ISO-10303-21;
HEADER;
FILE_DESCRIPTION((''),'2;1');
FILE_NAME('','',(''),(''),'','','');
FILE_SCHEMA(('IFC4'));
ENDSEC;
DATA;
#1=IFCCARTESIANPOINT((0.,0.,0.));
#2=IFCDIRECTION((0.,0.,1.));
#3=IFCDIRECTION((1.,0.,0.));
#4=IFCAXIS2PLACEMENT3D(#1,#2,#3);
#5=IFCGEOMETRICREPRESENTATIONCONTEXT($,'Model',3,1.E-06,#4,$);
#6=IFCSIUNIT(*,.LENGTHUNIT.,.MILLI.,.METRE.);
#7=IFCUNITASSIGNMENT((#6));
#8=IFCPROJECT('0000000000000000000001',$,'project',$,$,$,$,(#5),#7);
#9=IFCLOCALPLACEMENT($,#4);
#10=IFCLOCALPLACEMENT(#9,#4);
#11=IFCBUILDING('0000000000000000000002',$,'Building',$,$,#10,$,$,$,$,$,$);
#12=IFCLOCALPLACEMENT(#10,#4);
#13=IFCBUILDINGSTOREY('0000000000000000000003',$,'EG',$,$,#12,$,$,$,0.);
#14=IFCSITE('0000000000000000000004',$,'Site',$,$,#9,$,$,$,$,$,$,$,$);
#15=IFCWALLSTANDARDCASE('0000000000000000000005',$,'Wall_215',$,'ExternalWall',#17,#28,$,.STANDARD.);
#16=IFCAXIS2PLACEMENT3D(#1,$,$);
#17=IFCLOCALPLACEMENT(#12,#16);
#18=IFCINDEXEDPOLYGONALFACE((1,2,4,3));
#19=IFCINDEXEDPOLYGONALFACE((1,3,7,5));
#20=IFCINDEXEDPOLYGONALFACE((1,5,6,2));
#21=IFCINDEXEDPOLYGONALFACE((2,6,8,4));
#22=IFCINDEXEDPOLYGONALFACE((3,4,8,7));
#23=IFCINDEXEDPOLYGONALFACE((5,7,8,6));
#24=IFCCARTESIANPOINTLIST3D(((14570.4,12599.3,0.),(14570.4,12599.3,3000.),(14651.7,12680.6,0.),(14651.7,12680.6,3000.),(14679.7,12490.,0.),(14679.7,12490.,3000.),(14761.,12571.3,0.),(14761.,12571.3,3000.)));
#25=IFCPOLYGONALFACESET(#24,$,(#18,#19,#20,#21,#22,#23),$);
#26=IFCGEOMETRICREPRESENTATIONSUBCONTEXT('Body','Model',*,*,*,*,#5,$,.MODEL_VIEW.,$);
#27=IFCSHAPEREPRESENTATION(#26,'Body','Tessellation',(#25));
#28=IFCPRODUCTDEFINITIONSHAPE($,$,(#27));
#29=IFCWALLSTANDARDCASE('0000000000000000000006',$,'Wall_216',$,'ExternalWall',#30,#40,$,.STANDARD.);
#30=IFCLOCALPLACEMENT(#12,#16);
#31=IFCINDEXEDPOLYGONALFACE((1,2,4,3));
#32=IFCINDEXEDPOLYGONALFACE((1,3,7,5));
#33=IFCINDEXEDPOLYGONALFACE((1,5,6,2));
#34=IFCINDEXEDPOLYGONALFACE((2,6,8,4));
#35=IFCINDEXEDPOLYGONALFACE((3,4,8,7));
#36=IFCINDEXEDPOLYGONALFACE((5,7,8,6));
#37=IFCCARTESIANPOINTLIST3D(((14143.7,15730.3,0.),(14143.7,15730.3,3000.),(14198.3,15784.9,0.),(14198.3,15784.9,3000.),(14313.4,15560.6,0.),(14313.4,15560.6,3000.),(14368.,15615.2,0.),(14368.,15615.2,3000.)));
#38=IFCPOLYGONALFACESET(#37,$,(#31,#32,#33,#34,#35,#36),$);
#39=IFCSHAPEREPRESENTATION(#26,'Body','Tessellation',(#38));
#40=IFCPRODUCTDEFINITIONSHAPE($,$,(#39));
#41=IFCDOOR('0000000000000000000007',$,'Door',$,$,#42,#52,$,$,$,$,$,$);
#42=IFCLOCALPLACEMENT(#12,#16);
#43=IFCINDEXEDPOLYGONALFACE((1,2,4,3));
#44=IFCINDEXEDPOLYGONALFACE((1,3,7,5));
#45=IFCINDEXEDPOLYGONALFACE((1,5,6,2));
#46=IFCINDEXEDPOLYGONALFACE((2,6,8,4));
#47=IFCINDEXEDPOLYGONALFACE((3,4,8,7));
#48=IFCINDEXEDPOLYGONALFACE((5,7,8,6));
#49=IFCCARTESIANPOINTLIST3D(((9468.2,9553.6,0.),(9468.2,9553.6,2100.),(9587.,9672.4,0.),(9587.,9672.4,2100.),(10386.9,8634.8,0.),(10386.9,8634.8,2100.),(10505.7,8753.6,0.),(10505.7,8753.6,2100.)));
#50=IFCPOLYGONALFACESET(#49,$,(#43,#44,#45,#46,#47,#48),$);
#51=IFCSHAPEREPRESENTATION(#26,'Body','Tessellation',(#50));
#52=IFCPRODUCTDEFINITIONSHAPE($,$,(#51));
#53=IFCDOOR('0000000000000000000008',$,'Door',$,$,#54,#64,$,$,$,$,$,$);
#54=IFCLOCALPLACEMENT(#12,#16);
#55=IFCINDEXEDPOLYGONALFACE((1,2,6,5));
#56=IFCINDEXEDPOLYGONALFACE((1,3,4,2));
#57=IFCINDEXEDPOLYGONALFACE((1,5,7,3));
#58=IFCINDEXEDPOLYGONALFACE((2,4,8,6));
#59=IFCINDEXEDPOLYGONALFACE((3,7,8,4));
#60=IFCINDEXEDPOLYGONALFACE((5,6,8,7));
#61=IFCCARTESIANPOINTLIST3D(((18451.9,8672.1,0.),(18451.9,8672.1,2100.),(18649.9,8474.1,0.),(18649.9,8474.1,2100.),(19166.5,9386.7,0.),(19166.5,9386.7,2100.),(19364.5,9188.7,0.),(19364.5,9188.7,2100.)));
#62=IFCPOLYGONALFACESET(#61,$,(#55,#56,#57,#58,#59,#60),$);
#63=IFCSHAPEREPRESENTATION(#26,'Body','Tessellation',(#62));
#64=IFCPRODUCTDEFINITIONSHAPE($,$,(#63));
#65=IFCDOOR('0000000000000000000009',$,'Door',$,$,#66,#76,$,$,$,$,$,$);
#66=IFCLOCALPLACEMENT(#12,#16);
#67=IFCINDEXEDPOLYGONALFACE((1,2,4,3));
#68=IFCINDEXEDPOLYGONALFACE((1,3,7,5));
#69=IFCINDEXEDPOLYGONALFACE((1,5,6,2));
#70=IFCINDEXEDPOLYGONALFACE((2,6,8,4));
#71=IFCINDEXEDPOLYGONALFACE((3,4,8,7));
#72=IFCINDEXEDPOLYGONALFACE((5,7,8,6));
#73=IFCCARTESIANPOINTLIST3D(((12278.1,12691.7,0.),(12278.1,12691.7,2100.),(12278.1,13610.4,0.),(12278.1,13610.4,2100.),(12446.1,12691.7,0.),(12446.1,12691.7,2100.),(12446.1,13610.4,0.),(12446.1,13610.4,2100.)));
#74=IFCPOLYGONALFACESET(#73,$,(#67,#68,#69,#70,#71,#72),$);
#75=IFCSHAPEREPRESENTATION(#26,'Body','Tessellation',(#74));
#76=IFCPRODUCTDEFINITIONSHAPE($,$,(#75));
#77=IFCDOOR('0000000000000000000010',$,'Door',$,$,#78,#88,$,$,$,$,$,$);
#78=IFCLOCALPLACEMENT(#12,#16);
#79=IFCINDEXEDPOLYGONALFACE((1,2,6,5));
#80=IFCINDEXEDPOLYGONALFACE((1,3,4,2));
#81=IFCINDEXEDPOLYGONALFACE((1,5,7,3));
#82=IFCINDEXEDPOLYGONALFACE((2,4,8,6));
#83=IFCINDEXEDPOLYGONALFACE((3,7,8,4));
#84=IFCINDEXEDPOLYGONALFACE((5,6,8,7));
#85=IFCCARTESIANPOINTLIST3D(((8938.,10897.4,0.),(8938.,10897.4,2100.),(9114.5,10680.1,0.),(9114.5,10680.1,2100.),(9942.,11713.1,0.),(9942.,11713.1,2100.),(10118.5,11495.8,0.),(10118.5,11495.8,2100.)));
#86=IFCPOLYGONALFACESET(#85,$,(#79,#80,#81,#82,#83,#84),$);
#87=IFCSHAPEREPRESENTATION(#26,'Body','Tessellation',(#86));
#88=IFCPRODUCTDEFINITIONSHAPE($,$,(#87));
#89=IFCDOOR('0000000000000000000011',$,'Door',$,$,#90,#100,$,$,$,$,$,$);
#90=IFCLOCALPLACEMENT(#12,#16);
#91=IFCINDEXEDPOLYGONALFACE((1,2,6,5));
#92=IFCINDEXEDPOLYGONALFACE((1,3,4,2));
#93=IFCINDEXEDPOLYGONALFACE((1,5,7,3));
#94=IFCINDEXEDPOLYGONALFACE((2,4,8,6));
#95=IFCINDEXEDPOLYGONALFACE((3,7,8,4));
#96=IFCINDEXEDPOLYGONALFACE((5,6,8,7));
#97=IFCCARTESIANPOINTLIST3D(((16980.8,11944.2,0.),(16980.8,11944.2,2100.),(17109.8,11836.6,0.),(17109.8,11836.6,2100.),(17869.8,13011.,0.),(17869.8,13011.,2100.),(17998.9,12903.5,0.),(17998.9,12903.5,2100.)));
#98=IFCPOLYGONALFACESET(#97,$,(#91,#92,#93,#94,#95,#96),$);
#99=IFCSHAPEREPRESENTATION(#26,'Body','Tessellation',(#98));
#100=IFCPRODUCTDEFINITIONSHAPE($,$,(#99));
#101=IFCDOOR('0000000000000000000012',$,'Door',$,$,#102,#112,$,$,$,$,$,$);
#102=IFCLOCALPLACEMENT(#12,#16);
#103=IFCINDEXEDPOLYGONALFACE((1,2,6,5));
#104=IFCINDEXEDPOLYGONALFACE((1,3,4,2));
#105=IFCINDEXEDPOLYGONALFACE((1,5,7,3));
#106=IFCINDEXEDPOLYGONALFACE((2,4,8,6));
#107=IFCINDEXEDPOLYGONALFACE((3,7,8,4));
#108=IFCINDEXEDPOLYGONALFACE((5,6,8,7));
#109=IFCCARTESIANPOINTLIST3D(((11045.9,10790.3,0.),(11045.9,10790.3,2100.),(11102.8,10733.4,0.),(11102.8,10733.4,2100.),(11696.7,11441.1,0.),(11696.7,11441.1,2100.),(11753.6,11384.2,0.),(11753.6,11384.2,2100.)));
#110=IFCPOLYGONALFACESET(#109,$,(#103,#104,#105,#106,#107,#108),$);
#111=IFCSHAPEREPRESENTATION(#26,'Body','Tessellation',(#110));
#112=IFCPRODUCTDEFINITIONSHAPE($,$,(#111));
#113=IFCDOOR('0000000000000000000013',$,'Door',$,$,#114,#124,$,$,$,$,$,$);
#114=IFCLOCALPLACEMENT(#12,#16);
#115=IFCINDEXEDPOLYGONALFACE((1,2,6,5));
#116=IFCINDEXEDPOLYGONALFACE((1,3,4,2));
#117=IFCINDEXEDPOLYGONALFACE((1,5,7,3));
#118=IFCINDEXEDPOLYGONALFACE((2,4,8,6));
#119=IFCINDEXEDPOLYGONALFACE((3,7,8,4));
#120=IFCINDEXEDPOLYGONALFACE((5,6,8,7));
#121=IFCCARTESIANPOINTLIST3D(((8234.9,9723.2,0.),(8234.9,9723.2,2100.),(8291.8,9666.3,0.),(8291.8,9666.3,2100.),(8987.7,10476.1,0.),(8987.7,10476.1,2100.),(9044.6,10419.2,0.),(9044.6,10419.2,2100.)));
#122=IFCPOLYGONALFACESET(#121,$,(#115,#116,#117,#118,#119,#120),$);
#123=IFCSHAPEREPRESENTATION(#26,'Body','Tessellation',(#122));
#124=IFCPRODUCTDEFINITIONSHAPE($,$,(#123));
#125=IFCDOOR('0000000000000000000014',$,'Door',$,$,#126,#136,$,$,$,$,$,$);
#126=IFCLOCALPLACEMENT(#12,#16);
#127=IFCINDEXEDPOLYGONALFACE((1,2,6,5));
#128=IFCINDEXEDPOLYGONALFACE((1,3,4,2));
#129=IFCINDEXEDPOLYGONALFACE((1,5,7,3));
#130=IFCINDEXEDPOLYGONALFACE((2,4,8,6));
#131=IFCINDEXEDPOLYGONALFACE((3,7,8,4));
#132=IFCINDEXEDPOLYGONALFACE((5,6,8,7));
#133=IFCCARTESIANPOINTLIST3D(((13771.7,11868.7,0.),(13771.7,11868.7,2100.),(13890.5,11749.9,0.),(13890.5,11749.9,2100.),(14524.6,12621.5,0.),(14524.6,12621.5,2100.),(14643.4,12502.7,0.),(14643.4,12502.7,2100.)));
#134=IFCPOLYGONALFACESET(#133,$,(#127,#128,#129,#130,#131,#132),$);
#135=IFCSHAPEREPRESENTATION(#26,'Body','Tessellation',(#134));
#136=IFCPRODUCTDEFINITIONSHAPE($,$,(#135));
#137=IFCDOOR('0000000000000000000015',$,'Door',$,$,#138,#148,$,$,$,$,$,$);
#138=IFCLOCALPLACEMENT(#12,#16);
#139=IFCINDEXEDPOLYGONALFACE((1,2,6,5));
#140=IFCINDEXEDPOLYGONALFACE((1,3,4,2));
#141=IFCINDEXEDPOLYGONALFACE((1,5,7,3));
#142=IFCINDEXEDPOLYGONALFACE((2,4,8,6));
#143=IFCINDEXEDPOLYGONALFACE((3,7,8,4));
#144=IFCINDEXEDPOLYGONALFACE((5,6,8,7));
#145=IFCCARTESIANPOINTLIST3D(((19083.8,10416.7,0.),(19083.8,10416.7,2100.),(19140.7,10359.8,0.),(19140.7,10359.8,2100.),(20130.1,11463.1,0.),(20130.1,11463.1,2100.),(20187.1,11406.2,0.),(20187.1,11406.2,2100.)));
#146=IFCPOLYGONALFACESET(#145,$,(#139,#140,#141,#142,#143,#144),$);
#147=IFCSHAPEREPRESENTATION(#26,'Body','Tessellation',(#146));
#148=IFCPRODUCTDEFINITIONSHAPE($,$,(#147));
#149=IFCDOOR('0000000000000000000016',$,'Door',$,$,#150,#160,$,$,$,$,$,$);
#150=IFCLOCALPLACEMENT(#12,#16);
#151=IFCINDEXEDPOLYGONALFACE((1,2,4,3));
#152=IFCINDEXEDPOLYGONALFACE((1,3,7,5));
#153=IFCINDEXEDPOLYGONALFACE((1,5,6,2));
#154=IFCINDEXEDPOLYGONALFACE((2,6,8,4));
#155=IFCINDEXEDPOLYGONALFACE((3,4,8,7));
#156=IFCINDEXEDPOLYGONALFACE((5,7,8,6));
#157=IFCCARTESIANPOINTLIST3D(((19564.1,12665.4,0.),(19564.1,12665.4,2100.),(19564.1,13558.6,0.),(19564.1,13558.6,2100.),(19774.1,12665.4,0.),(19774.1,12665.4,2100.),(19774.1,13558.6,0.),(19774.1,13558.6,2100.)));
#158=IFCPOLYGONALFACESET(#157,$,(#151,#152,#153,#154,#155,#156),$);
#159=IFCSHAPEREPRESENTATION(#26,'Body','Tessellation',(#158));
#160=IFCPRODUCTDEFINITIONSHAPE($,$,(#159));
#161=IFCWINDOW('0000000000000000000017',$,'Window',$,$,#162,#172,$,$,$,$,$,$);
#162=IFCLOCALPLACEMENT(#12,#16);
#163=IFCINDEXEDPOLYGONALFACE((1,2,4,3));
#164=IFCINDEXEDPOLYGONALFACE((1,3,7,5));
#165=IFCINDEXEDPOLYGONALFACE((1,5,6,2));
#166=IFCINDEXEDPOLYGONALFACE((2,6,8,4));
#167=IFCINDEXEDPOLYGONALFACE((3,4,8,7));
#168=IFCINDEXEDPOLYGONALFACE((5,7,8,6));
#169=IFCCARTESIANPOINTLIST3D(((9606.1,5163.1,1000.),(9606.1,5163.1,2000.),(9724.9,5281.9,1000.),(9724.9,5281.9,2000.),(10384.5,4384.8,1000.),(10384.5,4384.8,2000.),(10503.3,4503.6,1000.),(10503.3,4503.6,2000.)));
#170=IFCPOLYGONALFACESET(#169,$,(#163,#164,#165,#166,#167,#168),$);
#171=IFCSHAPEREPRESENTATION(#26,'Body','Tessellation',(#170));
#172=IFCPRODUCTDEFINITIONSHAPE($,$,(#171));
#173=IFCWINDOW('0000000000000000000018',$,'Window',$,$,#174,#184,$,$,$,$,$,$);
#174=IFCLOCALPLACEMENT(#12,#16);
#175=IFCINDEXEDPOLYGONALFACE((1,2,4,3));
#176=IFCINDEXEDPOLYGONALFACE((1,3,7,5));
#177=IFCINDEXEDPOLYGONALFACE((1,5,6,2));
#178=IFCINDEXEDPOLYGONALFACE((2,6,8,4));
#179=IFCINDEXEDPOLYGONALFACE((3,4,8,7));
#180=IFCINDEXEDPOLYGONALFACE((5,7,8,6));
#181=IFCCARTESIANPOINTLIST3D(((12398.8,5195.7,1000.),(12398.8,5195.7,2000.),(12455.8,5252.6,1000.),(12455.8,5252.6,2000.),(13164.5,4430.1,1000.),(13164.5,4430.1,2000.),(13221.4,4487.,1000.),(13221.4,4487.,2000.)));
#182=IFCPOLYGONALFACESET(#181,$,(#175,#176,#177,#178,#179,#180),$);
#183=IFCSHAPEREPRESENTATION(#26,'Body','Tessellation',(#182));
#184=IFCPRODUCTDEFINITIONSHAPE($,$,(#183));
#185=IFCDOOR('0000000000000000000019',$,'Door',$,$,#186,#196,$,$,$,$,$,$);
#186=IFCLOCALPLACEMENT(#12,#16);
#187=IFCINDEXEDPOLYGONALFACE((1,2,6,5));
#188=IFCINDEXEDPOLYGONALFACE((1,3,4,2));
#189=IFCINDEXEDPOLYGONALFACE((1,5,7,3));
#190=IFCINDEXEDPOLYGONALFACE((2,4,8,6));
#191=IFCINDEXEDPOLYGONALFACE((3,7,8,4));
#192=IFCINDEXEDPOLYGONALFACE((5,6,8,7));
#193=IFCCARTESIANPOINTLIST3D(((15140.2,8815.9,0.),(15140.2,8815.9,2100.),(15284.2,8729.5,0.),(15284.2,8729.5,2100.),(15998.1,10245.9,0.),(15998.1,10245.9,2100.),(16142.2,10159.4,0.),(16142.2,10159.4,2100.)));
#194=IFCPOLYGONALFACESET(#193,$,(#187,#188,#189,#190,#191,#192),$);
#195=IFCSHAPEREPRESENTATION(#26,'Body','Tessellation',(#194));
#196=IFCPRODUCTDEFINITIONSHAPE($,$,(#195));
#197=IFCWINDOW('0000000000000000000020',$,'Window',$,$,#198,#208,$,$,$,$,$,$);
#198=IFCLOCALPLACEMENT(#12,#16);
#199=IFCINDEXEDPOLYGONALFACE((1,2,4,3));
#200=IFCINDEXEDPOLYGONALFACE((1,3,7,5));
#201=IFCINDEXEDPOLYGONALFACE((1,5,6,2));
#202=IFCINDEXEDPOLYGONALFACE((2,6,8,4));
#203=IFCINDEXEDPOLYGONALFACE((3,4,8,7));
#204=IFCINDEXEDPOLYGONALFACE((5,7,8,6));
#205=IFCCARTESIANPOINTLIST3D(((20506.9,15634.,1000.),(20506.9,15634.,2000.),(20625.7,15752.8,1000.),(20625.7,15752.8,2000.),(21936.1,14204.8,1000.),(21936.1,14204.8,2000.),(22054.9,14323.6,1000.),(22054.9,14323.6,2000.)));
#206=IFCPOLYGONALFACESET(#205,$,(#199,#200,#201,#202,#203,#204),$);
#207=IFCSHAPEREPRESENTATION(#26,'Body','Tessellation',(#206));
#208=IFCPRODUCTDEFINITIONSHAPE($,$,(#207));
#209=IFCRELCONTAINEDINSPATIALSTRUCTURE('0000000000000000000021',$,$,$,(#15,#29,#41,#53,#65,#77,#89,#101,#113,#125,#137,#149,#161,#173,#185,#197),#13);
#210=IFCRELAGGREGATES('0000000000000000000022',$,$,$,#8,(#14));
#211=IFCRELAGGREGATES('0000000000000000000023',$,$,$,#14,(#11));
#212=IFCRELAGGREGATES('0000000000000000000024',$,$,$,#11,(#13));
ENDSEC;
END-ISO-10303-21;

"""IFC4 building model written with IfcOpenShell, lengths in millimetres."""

from ifc_helpers import new_model, si_unit, frame, origin_with_axes, place, context, subcontext, project, spatial, rectangle, extrude, element, save


model = new_model("IFC4")

# Units and contexts
model_context = context("Model", 3, precision=1e-06, world=origin_with_axes())
body_context = subcontext(model_context, "Body", "Model", "MODEL_VIEW")
ifc_project = project(units=[si_unit("LENGTHUNIT", "METRE", prefix="MILLI")], contexts=[model_context])

# Site, building, storey
site_placement = place(None, origin_with_axes())
site = spatial("IfcSite", under=ifc_project, at=site_placement, Name="Site")
building_placement = place(site_placement, origin_with_axes())
building = spatial("IfcBuilding", under=site, at=building_placement, Name="Building")
storey_placement = place(building_placement, origin_with_axes())
storey = spatial("IfcBuildingStorey", under=building, at=storey_placement, Name="EG", Elevation=0.0)

# Walls
wall_1_placement = place(storey_placement, origin_with_axes())
element("IfcWallStandardCase", 1, at=wall_1_placement, inside=storey, Name="Wall_215", ObjectType="ExternalWall", PredefinedType="STANDARD", context=body_context, shape_type="SweptSolid", body=[
    extrude(rectangle(XDim=154.6, YDim=115.0), frame((14665.7, 12585.3, 0.0), z_axis=(0.0, 0.0, 1.0), x_axis=(0.707107, -0.707107, 0.0)), (0.0, 0.0, 1.0), 3000.0),
])
wall_2_placement = place(storey_placement, origin_with_axes())
element("IfcWallStandardCase", 2, at=wall_2_placement, inside=storey, Name="Wall_216", ObjectType="ExternalWall", PredefinedType="STANDARD", context=body_context, shape_type="SweptSolid", body=[
    extrude(rectangle(XDim=77.3, YDim=240.0), frame((14255.8, 15672.8, 0.0), z_axis=(0.0, 0.0, 1.0), x_axis=(-0.707107, -0.707107, 0.0)), (0.0, 0.0, 1.0), 3000.0),
])

# Doors
door_1_placement = place(storey_placement, origin_with_axes())
element("IfcDoor", 3, at=door_1_placement, inside=storey, Name="Door", context=body_context, shape_type="SweptSolid", body=[
    extrude(rectangle(XDim=1299.3, YDim=168.0), frame((9986.9, 9153.6, 0.0), z_axis=(0.0, 0.0, 1.0), x_axis=(0.707107, -0.707107, 0.0)), (0.0, 0.0, 1.0), 2100.0),
])
door_2_placement = place(storey_placement, origin_with_axes())
element("IfcDoor", 4, at=door_2_placement, inside=storey, Name="Door", context=body_context, shape_type="SweptSolid", body=[
    extrude(rectangle(XDim=1010.6, YDim=280.0), frame((18908.2, 8930.4, 0.0), z_axis=(0.0, 0.0, 1.0), x_axis=(-0.707107, -0.707107, 0.0)), (0.0, 0.0, 1.0), 2100.0),
])
door_3_placement = place(storey_placement, origin_with_axes())
element("IfcDoor", 5, at=door_3_placement, inside=storey, Name="Door", context=body_context, shape_type="SweptSolid", body=[
    extrude(rectangle(XDim=918.8, YDim=168.0), frame((12362.1, 13151.0, 0.0), z_axis=(0.0, 0.0, 1.0), x_axis=(0.0, -1.0, 0.0)), (0.0, 0.0, 1.0), 2100.0),
])
door_4_placement = place(storey_placement, origin_with_axes())
element("IfcDoor", 6, at=door_4_placement, inside=storey, Name="Door", context=body_context, shape_type="SweptSolid", body=[
    extrude(rectangle(XDim=1293.6, YDim=280.0), frame((9528.3, 11196.6, 0.0), z_axis=(0.0, 0.0, 1.0), x_axis=(-0.776114, -0.630593, 0.0)), (0.0, 0.0, 1.0), 2100.0),
])
door_5_placement = place(storey_placement, origin_with_axes())
element("IfcDoor", 7, at=door_5_placement, inside=storey, Name="Door", context=body_context, shape_type="SweptSolid", body=[
    extrude(rectangle(XDim=1388.7, YDim=168.0), frame((17489.8, 12423.8, 0.0), z_axis=(0.0, 0.0, 1.0), x_axis=(-0.640184, -0.768221, 0.0)), (0.0, 0.0, 1.0), 2100.0),
])
door_6_placement = place(storey_placement, origin_with_axes())
element("IfcDoor", 8, at=door_6_placement, inside=storey, Name="Door", context=body_context, shape_type="SweptSolid", body=[
    extrude(rectangle(XDim=920.3, YDim=80.5), frame((11399.7, 11087.2, 0.0), z_axis=(0.0, 0.0, 1.0), x_axis=(-0.707107, -0.707107, 0.0)), (0.0, 0.0, 1.0), 2100.0),
])
door_7_placement = place(storey_placement, origin_with_axes())
element("IfcDoor", 9, at=door_7_placement, inside=storey, Name="Door", context=body_context, shape_type="SweptSolid", body=[
    extrude(rectangle(XDim=1064.7, YDim=80.5), frame((8639.8, 10071.2, 0.0), z_axis=(0.0, 0.0, 1.0), x_axis=(0.707107, 0.707107, 0.0)), (0.0, 0.0, 1.0), 2100.0),
])
door_8_placement = place(storey_placement, origin_with_axes())
element("IfcDoor", 10, at=door_8_placement, inside=storey, Name="Door", context=body_context, shape_type="SweptSolid", body=[
    extrude(rectangle(XDim=1064.7, YDim=168.0), frame((14207.5, 12185.7, 0.0), z_axis=(0.0, 0.0, 1.0), x_axis=(-0.707107, -0.707107, 0.0)), (0.0, 0.0, 1.0), 2100.0),
])
door_9_placement = place(storey_placement, origin_with_axes())
element("IfcDoor", 11, at=door_9_placement, inside=storey, Name="Door", context=body_context, shape_type="SweptSolid", body=[
    extrude(rectangle(XDim=1479.8, YDim=80.5), frame((19635.4, 10911.5, 0.0), z_axis=(0.0, 0.0, 1.0), x_axis=(-0.707107, -0.707107, 0.0)), (0.0, 0.0, 1.0), 2100.0),
])
door_10_placement = place(storey_placement, origin_with_axes())
element("IfcDoor", 12, at=door_10_placement, inside=storey, Name="Door", context=body_context, shape_type="SweptSolid", body=[
    extrude(rectangle(XDim=893.2, YDim=210.0), frame((19669.1, 13112.0, 0.0), z_axis=(0.0, 0.0, 1.0), x_axis=(0.0, -1.0, 0.0)), (0.0, 0.0, 1.0), 2100.0),
])

# Windows
window_1_placement = place(storey_placement, origin_with_axes())
element("IfcWindow", 13, at=window_1_placement, inside=storey, Name="Window", context=body_context, shape_type="SweptSolid", body=[
    extrude(rectangle(XDim=1100.8, YDim=168.0), frame((10054.7, 4833.3, 1000.0), z_axis=(0.0, 0.0, 1.0), x_axis=(0.707107, -0.707107, 0.0)), (0.0, 0.0, 1.0), 1000.0),
])
window_2_placement = place(storey_placement, origin_with_axes())
element("IfcWindow", 14, at=window_2_placement, inside=storey, Name="Window", context=body_context, shape_type="SweptSolid", body=[
    extrude(rectangle(XDim=1082.8, YDim=80.5), frame((12810.1, 4841.4, 1000.0), z_axis=(0.0, 0.0, 1.0), x_axis=(0.707107, -0.707107, 0.0)), (0.0, 0.0, 1.0), 1000.0),
])

# Door
door_11_placement = place(storey_placement, origin_with_axes())
element("IfcDoor", 15, at=door_11_placement, inside=storey, Name="Door", context=body_context, shape_type="SweptSolid", body=[
    extrude(rectangle(XDim=1667.6, YDim=168.0), frame((15641.2, 9487.7, 0.0), z_axis=(0.0, 0.0, 1.0), x_axis=(0.514496, 0.857493, 0.0)), (0.0, 0.0, 1.0), 2100.0),
])

# Window
window_3_placement = place(storey_placement, origin_with_axes())
element("IfcWindow", 16, at=window_3_placement, inside=storey, Name="Window", context=body_context, shape_type="SweptSolid", body=[
    extrude(rectangle(XDim=2021.1, YDim=168.0), frame((21280.9, 14978.8, 1000.0), z_axis=(0.0, 0.0, 1.0), x_axis=(0.707107, -0.707107, 0.0)), (0.0, 0.0, 1.0), 1000.0),
])

save(model, "model.ifc")
